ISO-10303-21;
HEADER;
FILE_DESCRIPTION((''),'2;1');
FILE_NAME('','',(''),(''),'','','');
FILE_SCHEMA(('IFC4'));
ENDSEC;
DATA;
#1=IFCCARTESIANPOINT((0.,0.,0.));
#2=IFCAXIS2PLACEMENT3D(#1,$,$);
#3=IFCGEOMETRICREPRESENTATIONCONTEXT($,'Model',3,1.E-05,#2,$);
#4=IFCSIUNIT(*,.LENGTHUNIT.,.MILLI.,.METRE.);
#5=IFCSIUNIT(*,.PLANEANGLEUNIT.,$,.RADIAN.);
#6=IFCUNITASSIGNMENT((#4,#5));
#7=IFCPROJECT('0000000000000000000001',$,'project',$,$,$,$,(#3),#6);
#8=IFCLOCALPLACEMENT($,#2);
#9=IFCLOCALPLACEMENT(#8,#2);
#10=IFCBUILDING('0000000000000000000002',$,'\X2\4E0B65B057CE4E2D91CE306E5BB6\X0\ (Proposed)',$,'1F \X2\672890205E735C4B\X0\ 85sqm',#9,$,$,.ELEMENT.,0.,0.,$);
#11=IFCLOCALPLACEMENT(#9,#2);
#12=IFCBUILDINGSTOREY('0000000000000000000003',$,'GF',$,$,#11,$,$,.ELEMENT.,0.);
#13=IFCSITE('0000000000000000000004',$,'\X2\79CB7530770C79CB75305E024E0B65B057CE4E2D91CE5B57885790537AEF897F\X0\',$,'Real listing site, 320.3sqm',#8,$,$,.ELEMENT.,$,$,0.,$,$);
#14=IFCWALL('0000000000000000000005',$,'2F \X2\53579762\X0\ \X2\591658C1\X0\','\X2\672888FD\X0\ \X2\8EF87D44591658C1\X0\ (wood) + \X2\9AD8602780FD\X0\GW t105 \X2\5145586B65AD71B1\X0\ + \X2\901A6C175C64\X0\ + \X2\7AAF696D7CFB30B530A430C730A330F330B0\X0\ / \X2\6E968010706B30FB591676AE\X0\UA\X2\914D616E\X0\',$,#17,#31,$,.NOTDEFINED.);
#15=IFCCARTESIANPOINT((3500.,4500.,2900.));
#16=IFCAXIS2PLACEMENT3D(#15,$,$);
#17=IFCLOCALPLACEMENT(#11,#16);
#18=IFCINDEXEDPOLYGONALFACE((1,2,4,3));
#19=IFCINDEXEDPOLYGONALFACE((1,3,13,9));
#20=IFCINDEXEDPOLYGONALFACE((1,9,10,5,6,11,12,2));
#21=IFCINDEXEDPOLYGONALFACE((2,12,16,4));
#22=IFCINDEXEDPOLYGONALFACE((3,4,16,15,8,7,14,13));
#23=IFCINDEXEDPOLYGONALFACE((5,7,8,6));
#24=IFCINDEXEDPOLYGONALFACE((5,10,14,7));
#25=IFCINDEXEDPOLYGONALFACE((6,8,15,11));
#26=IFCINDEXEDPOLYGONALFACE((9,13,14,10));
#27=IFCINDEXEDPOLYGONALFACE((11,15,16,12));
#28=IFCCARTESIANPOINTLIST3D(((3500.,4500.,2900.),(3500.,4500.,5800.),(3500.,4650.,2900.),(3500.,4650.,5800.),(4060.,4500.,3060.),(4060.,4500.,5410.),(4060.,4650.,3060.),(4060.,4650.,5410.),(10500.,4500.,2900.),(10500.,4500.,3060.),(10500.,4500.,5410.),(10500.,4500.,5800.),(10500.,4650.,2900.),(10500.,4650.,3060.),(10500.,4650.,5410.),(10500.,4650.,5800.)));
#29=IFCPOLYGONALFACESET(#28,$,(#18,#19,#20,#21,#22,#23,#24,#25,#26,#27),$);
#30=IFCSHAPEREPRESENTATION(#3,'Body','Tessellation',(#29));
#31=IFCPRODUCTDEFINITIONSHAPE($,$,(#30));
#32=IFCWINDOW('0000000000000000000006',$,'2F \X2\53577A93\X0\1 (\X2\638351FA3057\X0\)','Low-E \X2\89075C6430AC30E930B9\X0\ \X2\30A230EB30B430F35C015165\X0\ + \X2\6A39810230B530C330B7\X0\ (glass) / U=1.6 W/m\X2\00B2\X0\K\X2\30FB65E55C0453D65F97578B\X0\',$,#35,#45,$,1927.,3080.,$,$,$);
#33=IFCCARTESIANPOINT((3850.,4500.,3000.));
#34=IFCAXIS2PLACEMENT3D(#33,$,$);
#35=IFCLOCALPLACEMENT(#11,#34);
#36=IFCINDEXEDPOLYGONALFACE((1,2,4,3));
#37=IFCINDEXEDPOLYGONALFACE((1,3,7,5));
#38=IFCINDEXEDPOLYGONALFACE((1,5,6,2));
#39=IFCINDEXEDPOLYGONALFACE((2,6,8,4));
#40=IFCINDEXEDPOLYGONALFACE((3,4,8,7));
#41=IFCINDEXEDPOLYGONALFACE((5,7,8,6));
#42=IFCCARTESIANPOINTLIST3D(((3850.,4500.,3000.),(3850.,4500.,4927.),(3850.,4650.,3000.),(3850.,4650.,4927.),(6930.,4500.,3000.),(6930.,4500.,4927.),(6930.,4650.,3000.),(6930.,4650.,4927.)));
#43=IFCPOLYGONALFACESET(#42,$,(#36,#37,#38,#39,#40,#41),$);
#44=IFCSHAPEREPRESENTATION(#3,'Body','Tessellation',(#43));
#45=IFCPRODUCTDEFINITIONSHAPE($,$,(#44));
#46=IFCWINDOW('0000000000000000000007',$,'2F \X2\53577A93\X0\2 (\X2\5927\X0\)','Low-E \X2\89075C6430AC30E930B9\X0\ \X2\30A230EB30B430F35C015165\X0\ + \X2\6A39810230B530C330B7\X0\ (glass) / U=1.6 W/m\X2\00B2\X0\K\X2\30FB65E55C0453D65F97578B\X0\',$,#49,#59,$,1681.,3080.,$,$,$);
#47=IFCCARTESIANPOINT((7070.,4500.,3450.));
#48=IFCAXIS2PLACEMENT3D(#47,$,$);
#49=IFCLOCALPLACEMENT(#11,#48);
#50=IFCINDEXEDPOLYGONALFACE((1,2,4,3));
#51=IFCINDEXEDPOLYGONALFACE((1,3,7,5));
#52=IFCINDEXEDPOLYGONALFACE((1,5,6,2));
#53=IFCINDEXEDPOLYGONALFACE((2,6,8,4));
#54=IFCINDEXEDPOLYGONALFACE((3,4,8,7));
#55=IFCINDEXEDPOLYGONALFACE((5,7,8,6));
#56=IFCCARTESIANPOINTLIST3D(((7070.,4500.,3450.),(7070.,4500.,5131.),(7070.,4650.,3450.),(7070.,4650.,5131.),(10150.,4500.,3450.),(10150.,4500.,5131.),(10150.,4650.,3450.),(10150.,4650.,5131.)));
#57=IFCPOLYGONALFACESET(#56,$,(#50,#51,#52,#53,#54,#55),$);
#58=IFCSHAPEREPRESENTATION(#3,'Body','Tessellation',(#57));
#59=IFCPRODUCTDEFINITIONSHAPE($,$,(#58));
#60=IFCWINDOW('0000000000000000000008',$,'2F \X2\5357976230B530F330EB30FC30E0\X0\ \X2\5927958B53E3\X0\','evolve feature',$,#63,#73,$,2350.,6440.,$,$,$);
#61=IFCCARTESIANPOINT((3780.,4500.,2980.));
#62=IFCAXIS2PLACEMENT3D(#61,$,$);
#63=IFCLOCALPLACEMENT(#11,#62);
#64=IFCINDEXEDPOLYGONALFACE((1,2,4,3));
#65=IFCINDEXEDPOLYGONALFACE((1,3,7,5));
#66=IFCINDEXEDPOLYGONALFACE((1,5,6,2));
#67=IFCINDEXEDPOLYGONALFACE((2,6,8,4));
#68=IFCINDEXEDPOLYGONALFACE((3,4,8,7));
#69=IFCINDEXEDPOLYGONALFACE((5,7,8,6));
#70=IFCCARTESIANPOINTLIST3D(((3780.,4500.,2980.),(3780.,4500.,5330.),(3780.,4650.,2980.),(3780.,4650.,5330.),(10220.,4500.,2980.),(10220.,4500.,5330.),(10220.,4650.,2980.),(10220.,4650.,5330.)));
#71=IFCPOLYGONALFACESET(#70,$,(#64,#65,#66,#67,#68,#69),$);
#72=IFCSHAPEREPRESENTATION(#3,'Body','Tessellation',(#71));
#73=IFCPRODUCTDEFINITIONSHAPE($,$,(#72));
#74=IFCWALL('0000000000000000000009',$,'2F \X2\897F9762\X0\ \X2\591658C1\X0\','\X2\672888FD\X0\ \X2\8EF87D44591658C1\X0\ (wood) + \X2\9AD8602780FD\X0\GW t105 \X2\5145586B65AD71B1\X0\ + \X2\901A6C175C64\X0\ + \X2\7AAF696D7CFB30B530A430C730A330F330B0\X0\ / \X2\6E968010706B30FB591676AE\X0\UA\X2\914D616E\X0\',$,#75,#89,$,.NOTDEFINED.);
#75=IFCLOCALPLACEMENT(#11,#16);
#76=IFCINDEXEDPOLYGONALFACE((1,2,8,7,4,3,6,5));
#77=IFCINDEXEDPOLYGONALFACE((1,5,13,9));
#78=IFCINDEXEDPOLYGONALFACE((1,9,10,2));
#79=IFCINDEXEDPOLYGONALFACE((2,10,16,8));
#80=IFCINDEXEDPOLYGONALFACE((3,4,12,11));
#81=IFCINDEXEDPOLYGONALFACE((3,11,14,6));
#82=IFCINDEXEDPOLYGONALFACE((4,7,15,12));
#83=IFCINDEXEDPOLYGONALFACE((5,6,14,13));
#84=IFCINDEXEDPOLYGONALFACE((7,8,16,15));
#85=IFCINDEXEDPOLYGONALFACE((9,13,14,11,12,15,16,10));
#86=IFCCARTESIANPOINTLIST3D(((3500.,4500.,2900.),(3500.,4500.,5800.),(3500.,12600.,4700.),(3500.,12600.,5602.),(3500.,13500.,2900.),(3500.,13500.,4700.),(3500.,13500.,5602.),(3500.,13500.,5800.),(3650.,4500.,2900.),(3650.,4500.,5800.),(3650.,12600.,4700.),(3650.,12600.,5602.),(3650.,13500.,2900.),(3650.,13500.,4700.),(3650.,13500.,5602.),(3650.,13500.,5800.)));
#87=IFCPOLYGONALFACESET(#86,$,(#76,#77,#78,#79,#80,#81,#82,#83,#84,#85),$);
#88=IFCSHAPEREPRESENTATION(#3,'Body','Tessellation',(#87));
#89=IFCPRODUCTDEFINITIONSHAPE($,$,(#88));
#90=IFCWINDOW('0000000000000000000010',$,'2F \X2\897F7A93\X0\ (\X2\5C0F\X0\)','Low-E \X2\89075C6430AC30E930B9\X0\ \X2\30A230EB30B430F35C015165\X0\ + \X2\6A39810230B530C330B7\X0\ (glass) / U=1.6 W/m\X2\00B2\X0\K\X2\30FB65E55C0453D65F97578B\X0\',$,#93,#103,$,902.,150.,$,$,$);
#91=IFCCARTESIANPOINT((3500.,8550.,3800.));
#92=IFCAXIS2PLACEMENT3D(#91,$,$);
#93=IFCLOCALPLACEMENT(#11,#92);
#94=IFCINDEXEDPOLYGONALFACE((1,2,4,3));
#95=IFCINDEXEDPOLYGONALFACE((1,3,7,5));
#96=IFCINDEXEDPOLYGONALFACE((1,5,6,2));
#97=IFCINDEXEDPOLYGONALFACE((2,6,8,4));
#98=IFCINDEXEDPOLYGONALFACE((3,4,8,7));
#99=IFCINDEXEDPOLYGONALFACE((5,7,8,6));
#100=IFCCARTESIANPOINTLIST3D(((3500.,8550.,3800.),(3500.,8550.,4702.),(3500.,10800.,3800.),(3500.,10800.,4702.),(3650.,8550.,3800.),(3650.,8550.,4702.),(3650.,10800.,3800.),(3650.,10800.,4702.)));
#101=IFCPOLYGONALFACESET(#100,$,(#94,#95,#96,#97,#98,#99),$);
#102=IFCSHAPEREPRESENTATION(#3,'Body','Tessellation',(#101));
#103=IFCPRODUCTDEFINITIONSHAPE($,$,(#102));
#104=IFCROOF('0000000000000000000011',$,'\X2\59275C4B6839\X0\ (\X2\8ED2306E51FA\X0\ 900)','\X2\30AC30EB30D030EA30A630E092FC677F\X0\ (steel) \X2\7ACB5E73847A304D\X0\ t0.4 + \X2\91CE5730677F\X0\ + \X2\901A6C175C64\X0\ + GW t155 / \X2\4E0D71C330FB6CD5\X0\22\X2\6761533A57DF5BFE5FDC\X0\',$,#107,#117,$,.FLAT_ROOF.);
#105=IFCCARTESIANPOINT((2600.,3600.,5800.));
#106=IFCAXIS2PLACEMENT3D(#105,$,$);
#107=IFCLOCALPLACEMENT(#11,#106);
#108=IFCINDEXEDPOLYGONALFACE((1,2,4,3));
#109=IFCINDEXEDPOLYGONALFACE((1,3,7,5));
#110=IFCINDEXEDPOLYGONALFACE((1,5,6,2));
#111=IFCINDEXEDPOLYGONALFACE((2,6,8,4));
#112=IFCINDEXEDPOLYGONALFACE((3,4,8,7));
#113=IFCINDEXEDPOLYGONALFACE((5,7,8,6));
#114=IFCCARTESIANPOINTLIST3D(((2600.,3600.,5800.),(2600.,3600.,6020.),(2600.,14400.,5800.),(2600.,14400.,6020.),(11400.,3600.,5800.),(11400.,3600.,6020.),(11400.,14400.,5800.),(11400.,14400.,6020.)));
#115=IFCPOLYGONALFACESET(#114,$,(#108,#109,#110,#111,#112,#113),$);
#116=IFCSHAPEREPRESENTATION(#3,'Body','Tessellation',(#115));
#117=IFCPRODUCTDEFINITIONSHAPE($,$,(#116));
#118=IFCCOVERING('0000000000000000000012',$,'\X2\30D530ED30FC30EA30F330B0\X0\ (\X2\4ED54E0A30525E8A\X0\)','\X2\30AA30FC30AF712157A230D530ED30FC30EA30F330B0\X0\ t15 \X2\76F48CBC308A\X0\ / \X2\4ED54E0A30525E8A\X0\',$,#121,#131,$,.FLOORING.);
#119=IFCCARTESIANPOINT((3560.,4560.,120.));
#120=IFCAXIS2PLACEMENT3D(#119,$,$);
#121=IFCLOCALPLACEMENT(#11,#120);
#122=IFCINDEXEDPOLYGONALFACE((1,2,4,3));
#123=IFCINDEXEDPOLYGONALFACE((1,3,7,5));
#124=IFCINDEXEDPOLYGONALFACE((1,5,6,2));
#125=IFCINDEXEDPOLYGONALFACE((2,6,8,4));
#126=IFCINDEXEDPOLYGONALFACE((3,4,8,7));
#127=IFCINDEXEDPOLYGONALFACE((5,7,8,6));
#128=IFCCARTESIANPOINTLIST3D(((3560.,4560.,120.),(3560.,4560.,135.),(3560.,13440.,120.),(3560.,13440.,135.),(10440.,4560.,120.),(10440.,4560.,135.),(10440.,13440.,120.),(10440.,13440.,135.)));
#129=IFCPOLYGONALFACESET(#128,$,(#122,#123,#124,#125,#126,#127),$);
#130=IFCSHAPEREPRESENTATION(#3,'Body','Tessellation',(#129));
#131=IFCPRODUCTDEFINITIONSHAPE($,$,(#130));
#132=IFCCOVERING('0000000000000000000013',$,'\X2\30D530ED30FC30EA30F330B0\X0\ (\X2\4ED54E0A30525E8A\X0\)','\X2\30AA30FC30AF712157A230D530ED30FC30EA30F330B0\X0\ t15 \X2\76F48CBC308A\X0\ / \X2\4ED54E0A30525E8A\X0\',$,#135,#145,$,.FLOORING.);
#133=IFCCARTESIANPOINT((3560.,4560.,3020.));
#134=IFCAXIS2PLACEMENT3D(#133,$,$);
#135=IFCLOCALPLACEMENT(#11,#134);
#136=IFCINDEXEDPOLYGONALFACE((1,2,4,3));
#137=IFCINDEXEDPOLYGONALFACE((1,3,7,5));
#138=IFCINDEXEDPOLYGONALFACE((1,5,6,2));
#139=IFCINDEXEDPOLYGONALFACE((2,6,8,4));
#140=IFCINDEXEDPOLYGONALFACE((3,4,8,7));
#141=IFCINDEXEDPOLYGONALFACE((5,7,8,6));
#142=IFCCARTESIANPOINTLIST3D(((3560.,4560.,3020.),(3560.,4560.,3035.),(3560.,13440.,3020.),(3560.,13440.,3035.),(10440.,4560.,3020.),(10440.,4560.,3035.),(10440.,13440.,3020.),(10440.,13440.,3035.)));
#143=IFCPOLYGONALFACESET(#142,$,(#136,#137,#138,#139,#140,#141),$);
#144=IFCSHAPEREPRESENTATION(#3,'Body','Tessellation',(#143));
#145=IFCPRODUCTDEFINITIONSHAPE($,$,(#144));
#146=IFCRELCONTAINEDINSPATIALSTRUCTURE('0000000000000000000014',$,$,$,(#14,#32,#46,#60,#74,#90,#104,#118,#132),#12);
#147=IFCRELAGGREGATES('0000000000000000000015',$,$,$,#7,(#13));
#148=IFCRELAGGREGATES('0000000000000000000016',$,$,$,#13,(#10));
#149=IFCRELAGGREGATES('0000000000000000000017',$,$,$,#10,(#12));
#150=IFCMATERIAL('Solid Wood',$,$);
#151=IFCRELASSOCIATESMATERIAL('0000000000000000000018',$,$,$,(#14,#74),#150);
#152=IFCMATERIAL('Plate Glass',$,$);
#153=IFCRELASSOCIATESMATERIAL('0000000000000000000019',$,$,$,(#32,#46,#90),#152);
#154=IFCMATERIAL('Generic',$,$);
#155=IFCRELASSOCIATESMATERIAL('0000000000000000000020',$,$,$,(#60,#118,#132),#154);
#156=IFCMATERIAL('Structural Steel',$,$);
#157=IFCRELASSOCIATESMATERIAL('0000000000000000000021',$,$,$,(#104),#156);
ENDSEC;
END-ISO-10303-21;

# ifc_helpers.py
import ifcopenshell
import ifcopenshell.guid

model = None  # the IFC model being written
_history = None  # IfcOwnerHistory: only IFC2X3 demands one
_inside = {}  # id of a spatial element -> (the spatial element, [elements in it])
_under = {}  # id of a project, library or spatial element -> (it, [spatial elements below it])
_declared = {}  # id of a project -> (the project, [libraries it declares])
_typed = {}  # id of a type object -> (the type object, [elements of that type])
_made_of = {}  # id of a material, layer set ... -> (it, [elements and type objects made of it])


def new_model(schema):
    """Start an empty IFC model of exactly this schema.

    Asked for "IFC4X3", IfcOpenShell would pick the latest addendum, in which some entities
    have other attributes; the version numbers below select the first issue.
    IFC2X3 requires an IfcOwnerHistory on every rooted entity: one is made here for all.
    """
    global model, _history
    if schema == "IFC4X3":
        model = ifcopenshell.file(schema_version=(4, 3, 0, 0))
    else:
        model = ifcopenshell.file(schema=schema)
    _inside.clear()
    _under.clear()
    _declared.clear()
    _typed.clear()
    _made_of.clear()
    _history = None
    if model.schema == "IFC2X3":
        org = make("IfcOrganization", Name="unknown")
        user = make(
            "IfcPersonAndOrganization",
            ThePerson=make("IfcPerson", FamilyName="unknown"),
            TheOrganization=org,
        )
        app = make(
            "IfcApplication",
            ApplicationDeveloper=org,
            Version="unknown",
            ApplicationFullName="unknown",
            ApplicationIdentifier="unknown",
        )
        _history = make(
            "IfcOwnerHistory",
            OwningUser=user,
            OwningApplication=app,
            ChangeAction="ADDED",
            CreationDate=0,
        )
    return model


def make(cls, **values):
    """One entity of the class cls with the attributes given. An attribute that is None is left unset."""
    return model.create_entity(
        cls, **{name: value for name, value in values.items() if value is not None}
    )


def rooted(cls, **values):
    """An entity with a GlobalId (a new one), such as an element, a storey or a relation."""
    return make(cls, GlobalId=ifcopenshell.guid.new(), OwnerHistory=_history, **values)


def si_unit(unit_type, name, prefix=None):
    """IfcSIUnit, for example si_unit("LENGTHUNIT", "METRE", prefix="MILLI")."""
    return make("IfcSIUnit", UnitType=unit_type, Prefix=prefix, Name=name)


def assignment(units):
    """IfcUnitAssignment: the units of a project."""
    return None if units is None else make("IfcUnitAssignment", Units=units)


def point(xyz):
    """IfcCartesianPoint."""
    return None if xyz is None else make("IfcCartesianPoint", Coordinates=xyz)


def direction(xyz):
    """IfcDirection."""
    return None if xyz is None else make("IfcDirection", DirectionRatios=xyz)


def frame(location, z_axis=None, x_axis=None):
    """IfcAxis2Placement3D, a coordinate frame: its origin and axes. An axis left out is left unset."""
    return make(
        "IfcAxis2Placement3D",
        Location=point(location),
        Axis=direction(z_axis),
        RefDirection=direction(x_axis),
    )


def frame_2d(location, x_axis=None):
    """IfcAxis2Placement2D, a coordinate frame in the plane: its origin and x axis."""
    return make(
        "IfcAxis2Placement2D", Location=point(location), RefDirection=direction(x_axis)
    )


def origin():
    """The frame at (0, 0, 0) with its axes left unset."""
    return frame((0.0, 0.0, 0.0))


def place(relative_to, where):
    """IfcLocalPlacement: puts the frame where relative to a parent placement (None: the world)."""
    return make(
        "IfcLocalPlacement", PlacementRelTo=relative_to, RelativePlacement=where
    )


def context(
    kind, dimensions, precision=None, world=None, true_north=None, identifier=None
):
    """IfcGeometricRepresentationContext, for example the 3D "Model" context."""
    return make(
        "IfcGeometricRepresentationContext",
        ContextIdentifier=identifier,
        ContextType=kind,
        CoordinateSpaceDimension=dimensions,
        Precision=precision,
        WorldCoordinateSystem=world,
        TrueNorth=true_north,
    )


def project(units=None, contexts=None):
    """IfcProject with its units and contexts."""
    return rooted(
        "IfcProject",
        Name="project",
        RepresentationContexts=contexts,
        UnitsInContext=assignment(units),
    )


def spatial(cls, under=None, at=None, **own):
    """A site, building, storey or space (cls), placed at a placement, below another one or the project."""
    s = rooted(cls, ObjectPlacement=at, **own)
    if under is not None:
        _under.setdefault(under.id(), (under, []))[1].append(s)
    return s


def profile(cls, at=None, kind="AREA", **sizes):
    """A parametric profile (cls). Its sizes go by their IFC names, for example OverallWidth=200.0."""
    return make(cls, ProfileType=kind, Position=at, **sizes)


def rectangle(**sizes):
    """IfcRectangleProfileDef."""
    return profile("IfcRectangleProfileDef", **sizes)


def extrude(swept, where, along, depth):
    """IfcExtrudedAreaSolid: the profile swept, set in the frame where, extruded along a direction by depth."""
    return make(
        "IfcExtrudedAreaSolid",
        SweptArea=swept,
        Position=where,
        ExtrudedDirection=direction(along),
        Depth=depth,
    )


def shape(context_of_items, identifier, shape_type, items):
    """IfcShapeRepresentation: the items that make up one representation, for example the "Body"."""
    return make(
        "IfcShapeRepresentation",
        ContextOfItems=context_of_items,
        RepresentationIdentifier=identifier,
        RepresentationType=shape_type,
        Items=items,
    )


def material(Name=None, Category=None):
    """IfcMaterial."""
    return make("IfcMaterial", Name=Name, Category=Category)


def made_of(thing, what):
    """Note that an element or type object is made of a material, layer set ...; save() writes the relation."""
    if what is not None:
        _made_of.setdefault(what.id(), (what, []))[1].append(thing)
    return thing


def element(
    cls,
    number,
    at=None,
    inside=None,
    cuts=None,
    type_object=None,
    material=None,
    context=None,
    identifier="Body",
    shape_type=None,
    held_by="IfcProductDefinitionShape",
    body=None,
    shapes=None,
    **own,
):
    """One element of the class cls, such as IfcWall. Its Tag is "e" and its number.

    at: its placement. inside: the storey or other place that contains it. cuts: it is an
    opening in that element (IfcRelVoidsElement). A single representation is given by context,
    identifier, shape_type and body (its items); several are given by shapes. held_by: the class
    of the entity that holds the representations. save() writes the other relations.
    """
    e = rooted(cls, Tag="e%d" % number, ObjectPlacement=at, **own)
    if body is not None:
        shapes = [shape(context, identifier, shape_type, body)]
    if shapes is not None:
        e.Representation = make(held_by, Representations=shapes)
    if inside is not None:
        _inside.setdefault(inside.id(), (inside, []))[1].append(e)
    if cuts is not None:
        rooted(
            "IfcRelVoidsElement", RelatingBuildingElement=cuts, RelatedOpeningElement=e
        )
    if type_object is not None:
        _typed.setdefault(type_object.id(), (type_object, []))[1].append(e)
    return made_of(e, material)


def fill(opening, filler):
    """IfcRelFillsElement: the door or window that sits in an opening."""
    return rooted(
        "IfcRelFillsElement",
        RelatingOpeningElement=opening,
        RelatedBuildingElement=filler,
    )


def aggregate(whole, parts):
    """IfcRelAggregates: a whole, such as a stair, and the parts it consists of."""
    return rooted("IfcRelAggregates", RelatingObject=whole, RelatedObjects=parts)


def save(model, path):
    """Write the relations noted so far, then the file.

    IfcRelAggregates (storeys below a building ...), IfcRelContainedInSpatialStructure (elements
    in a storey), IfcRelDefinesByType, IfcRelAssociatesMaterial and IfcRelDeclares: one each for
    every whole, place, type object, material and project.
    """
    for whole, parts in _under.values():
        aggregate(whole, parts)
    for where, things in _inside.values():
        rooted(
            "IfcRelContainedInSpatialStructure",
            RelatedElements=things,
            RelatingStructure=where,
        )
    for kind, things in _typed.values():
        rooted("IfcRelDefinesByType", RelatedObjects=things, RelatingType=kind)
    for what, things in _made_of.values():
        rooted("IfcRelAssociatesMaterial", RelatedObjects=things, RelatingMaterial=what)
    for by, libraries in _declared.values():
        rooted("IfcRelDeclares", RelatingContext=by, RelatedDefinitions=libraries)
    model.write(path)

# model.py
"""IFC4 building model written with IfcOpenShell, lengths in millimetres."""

from ifc_helpers import new_model, si_unit, frame, frame_2d, origin, place, context, project, spatial, rectangle, extrude, material, element, fill, save


model = new_model("IFC4")

# Units and contexts
model_context = context("Model", 3, precision=1e-05, world=origin())
ifc_project = project(units=[si_unit("LENGTHUNIT", "METRE", prefix="MILLI"), si_unit("PLANEANGLEUNIT", "RADIAN")], contexts=[model_context])

# Site, building, storey
site_placement = place(None, origin())
site = spatial("IfcSite", under=ifc_project, at=site_placement, Name="秋田県秋田市下新城中野字街道端西", ObjectType="Real listing site, 320.3sqm", CompositionType="ELEMENT", RefElevation=0.0)
building_placement = place(site_placement, origin())
building = spatial("IfcBuilding", under=site, at=building_placement, Name="下新城中野の家 (Proposed)", ObjectType="1F 木造平屋 85sqm", CompositionType="ELEMENT", ElevationOfRefHeight=0.0, ElevationOfTerrain=0.0)
storey_placement = place(building_placement, origin())
storey = spatial("IfcBuildingStorey", under=building, at=storey_placement, Name="GF", CompositionType="ELEMENT", Elevation=0.0)

# Shared definitions
ifc_material_1 = material(Name="Solid Wood")
ifc_material_2 = material(Name="Generic")

# Shared definitions
ifc_material_3 = material(Name="Plate Glass")

# Wall, openings, windows
wall_1_placement = place(storey_placement, frame((3500.0, 4500.0, 2900.0)))
wall_1 = element("IfcWall", 1, at=wall_1_placement, inside=storey, material=ifc_material_1, Name="2F 南面 外壁", Description="木製 軸組外壁 (wood) + 高性能GW t105 充填断熱 + 通気層 + 窯業系サイディング / 準耐火・外皮UA配慮", PredefinedType="NOTDEFINED", context=model_context, shape_type="SweptSolid", body=[
    extrude(rectangle(XDim=7000.0, YDim=150.0, at=frame_2d((3500.0, 75.0))), frame((3500.0, 4500.0, 2900.0)), (0.0, 0.0, 1.0), 2900.0),
])
opening_1_placement = place(storey_placement, frame((3850.0, 4500.0, 3000.0)))
opening_1 = element("IfcOpeningElement", 2, at=opening_1_placement, cuts=wall_1, PredefinedType="NOTDEFINED", context=model_context, shape_type="SweptSolid", body=[
    extrude(rectangle(XDim=3080.0, YDim=150.0, at=frame_2d((1540.0, 75.0))), frame((3850.0, 4500.0, 3000.0)), (0.0, 0.0, 1.0), 1927.0),
])
opening_2_placement = place(storey_placement, frame((7070.0, 4500.0, 3450.0)))
opening_2 = element("IfcOpeningElement", 3, at=opening_2_placement, cuts=wall_1, PredefinedType="NOTDEFINED", context=model_context, shape_type="SweptSolid", body=[
    extrude(rectangle(XDim=3080.0, YDim=150.0, at=frame_2d((1540.0, 75.0))), frame((7070.0, 4500.0, 3450.0)), (0.0, 0.0, 1.0), 1681.0),
])
opening_3_placement = place(storey_placement, frame((3780.0, 4500.0, 2980.0)))
opening_3 = element("IfcOpeningElement", 4, at=opening_3_placement, cuts=wall_1, PredefinedType="NOTDEFINED", context=model_context, shape_type="SweptSolid", body=[
    extrude(rectangle(XDim=6440.0, YDim=150.0, at=frame_2d((3220.0, 75.0))), frame((3780.0, 4500.0, 2980.0)), (0.0, 0.0, 1.0), 2350.0),
])
window_1_placement = place(storey_placement, frame((3850.0, 4500.0, 3000.0)))
window_1 = element("IfcWindow", 5, at=window_1_placement, inside=storey, material=ifc_material_3, Name="2F 南窓1 (掃出し)", Description="Low-E 複層ガラス アルゴン封入 + 樹脂サッシ (glass) / U=1.6 W/m²K・日射取得型", OverallHeight=1927.0, OverallWidth=3080.0, context=model_context, shape_type="SweptSolid", body=[
    extrude(rectangle(XDim=3080.0, YDim=150.0, at=frame_2d((1540.0, 75.0))), frame((3850.0, 4500.0, 3000.0)), (0.0, 0.0, 1.0), 1927.0),
])
fill(opening_1, window_1)
window_2_placement = place(storey_placement, frame((7070.0, 4500.0, 3450.0)))
window_2 = element("IfcWindow", 6, at=window_2_placement, inside=storey, material=ifc_material_3, Name="2F 南窓2 (大)", Description="Low-E 複層ガラス アルゴン封入 + 樹脂サッシ (glass) / U=1.6 W/m²K・日射取得型", OverallHeight=1681.0, OverallWidth=3080.0, context=model_context, shape_type="SweptSolid", body=[
    extrude(rectangle(XDim=3080.0, YDim=150.0, at=frame_2d((1540.0, 75.0))), frame((7070.0, 4500.0, 3450.0)), (0.0, 0.0, 1.0), 1681.0),
])
fill(opening_2, window_2)
window_3_placement = place(storey_placement, frame((3780.0, 4500.0, 2980.0)))
window_3 = element("IfcWindow", 7, at=window_3_placement, inside=storey, material=ifc_material_2, Name="2F 南面サンルーム 大開口", Description="evolve feature", OverallHeight=2350.0, OverallWidth=6440.0, context=model_context, shape_type="SweptSolid", body=[
    extrude(rectangle(XDim=6440.0, YDim=150.0, at=frame_2d((3220.0, 75.0))), frame((3780.0, 4500.0, 2980.0)), (0.0, 0.0, 1.0), 2350.0),
])
fill(opening_3, window_3)

# Wall, opening, window
wall_2_placement = place(storey_placement, frame((3500.0, 4500.0, 2900.0)))
wall_2 = element("IfcWall", 8, at=wall_2_placement, inside=storey, material=ifc_material_1, Name="2F 西面 外壁", Description="木製 軸組外壁 (wood) + 高性能GW t105 充填断熱 + 通気層 + 窯業系サイディング / 準耐火・外皮UA配慮", PredefinedType="NOTDEFINED", context=model_context, shape_type="SweptSolid", body=[
    extrude(rectangle(XDim=150.0, YDim=9000.0, at=frame_2d((75.0, 4500.0))), frame((3500.0, 4500.0, 2900.0)), (0.0, 0.0, 1.0), 2900.0),
])
opening_4_placement = place(storey_placement, frame((3500.0, 8550.0, 3800.0)))
opening_4 = element("IfcOpeningElement", 9, at=opening_4_placement, cuts=wall_2, PredefinedType="NOTDEFINED", context=model_context, shape_type="SweptSolid", body=[
    extrude(rectangle(XDim=150.0, YDim=2250.0, at=frame_2d((75.0, 1125.0))), frame((3500.0, 8550.0, 3800.0)), (0.0, 0.0, 1.0), 902.0),
])
window_4_placement = place(storey_placement, frame((3500.0, 8550.0, 3800.0)))
window_4 = element("IfcWindow", 10, at=window_4_placement, inside=storey, material=ifc_material_3, Name="2F 西窓 (小)", Description="Low-E 複層ガラス アルゴン封入 + 樹脂サッシ (glass) / U=1.6 W/m²K・日射取得型", OverallHeight=902.0, OverallWidth=150.0, context=model_context, shape_type="SweptSolid", body=[
    extrude(rectangle(XDim=150.0, YDim=2250.0, at=frame_2d((75.0, 1125.0))), frame((3500.0, 8550.0, 3800.0)), (0.0, 0.0, 1.0), 902.0),
])
fill(opening_4, window_4)

# Roof
ifc_material_4 = material(Name="Structural Steel")
roof_placement = place(storey_placement, frame((2600.0, 3600.0, 5800.0)))
element("IfcRoof", 11, at=roof_placement, inside=storey, material=ifc_material_4, Name="大屋根 (軒の出 900)", Description="ガルバリウム鋼板 (steel) 立平葺き t0.4 + 野地板 + 通気層 + GW t155 / 不燃・法22条区域対応", PredefinedType="FLAT_ROOF", context=model_context, shape_type="SweptSolid", body=[
    extrude(rectangle(XDim=8800.0, YDim=10800.0, at=frame_2d((4400.0, 5400.0))), frame((2600.0, 3600.0, 5800.0)), (0.0, 0.0, 1.0), 220.0),
])

# Coverings
covering_1_placement = place(storey_placement, frame((3560.0, 4560.0, 120.0)))
element("IfcCovering", 12, at=covering_1_placement, inside=storey, material=ifc_material_2, Name="フローリング (仕上げ床)", Description="オーク無垢フローリング t15 直貼り / 仕上げ床", PredefinedType="FLOORING", context=model_context, shape_type="SweptSolid", body=[
    extrude(rectangle(XDim=6880.0, YDim=8880.0, at=frame_2d((3440.0, 4440.0))), frame((3560.0, 4560.0, 120.0)), (0.0, 0.0, 1.0), 15.0),
])
covering_2_placement = place(storey_placement, frame((3560.0, 4560.0, 3020.0)))
element("IfcCovering", 13, at=covering_2_placement, inside=storey, material=ifc_material_2, Name="フローリング (仕上げ床)", Description="オーク無垢フローリング t15 直貼り / 仕上げ床", PredefinedType="FLOORING", context=model_context, shape_type="SweptSolid", body=[
    extrude(rectangle(XDim=6880.0, YDim=8880.0, at=frame_2d((3440.0, 4440.0))), frame((3560.0, 4560.0, 3020.0)), (0.0, 0.0, 1.0), 15.0),
])

save(model, "model.ifc")
